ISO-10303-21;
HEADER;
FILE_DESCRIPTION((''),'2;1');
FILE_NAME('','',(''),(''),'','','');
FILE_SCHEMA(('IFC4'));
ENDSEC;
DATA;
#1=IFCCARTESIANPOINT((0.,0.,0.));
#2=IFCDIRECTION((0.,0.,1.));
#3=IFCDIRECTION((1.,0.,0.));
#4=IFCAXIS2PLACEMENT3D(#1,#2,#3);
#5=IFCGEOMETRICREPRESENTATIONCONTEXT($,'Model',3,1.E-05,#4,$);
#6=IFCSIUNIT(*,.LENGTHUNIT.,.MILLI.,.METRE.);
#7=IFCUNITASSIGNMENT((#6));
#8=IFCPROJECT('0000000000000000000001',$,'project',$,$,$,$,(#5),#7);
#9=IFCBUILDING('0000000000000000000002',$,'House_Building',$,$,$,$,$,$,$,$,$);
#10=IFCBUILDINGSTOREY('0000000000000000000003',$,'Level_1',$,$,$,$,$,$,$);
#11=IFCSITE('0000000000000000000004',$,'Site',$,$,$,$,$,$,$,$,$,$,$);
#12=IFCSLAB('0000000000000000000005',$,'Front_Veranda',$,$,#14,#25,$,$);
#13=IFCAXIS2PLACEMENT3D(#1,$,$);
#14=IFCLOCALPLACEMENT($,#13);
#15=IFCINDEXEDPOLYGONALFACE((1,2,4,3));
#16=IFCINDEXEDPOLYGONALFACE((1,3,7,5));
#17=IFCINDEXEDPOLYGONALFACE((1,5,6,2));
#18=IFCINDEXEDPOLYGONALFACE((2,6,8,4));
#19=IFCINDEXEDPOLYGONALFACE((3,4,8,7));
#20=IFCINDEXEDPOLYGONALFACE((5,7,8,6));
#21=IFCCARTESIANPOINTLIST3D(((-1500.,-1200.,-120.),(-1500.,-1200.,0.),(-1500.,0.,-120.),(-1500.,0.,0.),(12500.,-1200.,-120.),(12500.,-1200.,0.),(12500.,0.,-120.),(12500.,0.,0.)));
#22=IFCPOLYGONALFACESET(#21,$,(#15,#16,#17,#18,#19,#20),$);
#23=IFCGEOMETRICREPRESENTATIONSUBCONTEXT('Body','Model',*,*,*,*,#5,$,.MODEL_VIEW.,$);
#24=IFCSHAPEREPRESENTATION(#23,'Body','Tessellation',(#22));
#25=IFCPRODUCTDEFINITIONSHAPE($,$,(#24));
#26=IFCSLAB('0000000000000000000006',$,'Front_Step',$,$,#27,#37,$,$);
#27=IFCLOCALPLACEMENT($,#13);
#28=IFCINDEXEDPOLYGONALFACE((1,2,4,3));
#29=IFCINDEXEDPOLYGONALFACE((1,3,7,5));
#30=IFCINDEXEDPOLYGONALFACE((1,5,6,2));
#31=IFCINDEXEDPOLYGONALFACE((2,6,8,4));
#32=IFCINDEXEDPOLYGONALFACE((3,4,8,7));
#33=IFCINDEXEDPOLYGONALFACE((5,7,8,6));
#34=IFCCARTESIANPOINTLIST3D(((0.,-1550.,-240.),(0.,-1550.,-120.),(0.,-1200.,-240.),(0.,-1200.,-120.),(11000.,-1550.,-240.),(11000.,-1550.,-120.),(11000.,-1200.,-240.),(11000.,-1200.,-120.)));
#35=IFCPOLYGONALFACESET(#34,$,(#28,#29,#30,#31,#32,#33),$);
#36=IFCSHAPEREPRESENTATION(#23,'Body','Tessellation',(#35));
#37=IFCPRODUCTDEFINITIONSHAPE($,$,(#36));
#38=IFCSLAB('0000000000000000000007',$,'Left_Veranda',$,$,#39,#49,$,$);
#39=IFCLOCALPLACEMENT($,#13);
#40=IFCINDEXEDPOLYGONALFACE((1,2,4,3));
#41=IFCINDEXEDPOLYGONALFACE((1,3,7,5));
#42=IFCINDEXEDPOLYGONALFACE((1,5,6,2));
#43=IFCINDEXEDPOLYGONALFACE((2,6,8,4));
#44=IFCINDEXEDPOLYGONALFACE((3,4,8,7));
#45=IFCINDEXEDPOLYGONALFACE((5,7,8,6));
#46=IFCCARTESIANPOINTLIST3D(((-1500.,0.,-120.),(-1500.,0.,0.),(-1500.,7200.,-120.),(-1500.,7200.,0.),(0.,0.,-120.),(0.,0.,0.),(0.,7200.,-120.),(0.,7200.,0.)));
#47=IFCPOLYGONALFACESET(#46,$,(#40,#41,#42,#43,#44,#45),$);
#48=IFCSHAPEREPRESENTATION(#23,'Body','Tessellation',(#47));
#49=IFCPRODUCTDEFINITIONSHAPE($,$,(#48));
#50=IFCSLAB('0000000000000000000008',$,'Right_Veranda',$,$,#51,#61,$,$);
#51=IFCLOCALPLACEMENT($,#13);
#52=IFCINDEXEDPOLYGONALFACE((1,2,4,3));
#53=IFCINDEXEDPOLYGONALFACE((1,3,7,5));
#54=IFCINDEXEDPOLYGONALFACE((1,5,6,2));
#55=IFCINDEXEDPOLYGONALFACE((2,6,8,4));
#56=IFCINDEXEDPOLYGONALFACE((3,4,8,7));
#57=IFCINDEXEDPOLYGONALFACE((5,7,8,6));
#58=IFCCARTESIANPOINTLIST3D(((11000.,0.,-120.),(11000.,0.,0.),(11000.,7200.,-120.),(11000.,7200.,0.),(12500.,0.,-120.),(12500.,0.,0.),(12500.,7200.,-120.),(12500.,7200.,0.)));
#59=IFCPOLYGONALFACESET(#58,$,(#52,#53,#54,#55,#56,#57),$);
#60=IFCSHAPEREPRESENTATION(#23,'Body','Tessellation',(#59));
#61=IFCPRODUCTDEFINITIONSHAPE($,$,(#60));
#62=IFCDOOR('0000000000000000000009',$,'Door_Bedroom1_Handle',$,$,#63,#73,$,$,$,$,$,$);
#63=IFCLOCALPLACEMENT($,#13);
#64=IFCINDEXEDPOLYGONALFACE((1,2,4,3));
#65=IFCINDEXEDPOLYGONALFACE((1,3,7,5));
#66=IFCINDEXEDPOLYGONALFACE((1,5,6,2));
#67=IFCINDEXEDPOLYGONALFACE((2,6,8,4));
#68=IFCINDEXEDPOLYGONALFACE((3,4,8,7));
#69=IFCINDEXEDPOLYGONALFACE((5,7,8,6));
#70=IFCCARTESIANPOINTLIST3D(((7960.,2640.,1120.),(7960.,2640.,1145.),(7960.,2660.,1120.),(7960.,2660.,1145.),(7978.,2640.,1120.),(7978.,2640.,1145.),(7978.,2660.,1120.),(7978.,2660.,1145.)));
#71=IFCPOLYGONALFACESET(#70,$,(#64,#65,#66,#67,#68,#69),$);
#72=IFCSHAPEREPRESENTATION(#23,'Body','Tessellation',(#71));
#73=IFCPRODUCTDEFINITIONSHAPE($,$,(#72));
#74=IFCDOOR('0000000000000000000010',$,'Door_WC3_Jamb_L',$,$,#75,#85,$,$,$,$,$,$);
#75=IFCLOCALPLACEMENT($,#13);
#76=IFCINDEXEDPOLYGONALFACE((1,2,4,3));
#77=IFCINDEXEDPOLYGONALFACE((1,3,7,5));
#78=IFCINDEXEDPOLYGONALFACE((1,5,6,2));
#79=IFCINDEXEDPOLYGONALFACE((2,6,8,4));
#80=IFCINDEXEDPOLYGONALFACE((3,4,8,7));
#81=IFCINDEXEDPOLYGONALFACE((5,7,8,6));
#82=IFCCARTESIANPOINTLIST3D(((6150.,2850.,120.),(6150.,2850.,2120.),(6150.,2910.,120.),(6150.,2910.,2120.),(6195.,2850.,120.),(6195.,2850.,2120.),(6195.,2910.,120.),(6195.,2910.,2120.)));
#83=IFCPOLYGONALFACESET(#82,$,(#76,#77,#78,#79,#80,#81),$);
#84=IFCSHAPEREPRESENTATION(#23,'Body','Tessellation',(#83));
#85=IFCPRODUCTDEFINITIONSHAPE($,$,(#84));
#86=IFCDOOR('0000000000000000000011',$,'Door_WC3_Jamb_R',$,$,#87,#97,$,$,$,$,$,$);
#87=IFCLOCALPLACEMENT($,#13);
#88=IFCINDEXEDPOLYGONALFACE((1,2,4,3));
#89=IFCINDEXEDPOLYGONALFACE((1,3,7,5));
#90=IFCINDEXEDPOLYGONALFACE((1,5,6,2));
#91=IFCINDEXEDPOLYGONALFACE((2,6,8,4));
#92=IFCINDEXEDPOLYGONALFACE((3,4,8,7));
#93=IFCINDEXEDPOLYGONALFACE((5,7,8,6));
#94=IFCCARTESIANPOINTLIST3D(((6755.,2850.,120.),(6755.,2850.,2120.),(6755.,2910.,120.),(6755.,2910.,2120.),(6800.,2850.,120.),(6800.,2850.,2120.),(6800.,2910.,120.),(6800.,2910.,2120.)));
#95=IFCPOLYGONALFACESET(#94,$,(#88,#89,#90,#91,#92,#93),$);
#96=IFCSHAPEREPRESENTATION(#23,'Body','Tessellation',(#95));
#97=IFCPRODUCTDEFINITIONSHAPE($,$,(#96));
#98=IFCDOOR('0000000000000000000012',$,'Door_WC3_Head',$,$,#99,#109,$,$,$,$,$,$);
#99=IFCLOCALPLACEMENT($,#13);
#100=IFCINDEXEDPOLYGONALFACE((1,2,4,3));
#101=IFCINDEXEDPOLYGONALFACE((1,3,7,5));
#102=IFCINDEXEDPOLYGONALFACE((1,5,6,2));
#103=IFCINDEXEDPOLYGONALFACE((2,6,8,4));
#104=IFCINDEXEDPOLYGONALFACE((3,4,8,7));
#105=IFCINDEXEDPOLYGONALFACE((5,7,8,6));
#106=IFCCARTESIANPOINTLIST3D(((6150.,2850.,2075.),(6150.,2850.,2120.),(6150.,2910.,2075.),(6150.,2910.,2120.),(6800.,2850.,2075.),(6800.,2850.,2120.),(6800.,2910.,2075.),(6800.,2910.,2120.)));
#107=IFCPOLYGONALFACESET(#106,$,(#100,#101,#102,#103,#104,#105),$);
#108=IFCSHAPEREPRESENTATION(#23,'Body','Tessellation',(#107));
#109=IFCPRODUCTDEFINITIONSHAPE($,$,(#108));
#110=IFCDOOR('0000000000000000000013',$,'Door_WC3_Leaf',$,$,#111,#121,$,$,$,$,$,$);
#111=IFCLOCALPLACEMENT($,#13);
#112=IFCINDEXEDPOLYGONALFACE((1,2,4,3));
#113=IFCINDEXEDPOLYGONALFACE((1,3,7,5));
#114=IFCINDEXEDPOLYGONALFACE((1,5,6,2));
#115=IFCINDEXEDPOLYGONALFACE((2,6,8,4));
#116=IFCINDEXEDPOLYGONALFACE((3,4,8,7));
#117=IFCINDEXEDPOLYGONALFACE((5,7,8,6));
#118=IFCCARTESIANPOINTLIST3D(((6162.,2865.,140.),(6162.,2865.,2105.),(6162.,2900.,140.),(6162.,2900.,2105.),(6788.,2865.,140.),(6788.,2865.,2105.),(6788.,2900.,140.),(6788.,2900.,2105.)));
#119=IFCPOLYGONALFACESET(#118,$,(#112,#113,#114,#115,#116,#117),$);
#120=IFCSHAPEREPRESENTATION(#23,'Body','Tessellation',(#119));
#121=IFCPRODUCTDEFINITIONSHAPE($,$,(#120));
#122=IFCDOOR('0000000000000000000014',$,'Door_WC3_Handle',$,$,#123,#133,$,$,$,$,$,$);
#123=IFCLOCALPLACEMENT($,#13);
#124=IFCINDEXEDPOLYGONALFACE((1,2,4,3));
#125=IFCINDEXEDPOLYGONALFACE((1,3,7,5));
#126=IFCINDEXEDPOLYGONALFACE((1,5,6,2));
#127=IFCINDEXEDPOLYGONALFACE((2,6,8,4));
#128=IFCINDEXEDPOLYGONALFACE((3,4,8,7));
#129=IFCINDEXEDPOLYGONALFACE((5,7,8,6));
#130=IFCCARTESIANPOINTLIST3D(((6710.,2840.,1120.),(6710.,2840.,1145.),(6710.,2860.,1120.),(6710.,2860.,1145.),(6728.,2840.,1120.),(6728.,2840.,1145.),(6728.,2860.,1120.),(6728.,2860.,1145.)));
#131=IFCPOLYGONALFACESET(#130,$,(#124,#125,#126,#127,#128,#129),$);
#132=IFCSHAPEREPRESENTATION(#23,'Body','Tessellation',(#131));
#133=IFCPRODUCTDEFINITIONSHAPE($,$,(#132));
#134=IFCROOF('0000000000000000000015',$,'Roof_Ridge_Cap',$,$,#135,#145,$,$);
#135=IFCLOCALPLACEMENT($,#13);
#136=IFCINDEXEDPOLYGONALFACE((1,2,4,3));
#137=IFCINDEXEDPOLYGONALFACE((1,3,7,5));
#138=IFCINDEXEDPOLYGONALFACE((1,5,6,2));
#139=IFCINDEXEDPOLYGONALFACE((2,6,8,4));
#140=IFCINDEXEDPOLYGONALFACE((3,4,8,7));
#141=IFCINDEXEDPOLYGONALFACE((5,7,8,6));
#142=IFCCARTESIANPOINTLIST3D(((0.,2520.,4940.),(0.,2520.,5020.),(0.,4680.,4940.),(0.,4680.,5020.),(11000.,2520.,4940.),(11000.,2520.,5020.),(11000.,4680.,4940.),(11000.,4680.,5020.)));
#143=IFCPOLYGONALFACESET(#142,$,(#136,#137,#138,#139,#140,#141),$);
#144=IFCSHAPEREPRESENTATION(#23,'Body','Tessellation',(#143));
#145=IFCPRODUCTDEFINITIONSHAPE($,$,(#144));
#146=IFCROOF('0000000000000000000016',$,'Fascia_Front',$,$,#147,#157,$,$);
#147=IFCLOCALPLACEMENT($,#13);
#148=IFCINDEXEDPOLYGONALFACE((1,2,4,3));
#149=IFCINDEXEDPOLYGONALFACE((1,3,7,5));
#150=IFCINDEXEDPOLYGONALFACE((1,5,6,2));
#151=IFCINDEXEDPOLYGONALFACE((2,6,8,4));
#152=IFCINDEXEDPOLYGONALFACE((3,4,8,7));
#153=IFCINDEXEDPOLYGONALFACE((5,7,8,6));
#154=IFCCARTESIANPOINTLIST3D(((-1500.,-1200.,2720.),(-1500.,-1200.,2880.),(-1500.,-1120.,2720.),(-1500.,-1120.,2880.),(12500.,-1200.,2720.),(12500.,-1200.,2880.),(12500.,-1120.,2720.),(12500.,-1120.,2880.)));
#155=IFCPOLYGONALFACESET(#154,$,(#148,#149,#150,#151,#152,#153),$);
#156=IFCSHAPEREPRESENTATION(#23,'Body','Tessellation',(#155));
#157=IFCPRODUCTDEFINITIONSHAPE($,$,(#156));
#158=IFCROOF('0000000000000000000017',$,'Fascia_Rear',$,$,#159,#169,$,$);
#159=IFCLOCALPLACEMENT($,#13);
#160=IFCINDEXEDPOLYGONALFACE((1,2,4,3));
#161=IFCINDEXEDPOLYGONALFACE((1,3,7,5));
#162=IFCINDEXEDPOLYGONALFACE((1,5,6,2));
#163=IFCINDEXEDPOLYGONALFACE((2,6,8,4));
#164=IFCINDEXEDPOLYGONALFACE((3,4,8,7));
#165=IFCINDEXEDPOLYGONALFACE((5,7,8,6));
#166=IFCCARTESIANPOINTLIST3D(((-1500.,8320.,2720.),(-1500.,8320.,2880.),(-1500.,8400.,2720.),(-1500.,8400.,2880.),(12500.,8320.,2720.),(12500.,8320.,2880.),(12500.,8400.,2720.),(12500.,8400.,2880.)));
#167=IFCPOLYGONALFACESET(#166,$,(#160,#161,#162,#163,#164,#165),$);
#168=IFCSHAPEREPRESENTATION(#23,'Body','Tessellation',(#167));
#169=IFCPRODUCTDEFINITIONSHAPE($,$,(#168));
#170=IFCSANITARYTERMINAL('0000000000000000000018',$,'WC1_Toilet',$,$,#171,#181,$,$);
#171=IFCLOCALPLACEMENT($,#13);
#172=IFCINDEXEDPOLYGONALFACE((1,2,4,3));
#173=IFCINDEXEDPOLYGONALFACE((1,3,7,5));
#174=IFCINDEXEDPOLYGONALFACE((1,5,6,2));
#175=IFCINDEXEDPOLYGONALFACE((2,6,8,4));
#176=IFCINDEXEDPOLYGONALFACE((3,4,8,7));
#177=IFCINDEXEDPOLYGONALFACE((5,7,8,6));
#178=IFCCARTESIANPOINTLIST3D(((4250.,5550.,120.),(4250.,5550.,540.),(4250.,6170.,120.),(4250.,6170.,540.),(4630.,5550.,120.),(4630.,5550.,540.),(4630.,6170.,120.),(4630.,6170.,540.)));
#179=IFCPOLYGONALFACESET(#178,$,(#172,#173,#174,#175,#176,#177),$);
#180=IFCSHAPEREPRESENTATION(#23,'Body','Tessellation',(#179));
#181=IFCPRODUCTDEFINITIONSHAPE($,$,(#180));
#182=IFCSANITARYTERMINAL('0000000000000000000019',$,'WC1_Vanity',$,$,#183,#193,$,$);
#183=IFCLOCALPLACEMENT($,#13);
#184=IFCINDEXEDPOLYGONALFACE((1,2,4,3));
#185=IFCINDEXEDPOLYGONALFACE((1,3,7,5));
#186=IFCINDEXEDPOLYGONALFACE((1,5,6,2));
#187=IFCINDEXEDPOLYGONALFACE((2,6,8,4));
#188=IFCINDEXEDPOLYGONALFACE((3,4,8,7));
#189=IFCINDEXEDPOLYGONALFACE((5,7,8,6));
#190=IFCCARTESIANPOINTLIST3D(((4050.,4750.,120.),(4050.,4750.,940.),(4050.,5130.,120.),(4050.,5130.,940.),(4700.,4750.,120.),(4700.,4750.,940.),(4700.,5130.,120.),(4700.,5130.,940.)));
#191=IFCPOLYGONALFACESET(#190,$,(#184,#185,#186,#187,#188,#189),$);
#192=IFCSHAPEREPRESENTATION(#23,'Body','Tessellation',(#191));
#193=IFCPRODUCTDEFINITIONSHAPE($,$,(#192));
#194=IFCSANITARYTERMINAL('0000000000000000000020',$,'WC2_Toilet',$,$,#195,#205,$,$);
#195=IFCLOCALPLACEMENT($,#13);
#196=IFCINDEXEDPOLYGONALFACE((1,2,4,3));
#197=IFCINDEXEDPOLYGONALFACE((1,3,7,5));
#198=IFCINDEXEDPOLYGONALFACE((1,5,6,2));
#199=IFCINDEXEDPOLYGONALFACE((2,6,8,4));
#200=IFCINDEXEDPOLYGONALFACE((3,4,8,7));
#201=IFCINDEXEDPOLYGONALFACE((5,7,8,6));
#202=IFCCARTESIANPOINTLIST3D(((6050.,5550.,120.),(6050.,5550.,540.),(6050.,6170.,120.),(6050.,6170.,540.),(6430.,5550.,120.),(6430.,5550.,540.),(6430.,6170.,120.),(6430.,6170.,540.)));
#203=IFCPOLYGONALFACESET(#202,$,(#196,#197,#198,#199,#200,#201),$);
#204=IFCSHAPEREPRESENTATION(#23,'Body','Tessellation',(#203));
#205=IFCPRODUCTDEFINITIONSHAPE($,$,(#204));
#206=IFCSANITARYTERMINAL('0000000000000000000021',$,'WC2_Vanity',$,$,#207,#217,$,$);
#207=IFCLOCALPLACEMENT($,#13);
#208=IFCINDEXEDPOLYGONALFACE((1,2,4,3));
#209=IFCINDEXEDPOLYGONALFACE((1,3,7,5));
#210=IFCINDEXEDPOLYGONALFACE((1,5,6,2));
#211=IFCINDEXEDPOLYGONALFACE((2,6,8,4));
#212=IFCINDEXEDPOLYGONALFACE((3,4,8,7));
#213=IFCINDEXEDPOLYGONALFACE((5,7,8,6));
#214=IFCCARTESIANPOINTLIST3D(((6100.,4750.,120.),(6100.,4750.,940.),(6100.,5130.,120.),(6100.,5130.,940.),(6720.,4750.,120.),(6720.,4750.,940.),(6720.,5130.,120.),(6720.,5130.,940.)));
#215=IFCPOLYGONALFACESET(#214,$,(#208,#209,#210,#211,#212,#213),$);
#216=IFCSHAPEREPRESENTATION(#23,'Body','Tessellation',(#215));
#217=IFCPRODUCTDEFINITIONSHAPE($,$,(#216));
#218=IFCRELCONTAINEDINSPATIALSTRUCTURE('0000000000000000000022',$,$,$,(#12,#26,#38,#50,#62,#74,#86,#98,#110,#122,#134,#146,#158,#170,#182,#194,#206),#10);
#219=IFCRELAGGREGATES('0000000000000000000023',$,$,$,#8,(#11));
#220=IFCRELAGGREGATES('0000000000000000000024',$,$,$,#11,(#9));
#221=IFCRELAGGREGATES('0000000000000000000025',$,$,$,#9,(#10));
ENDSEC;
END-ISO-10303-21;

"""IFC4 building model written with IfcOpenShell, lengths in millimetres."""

from ifc_helpers import new_model, si_unit, frame, origin_with_axes, context, subcontext, project, spatial, polyline, outline, extrude, element, save


model = new_model("IFC4")

# Units and contexts
model_context = context("Model", 3, precision=1e-05, world=origin_with_axes())
body_context = subcontext(model_context, "Body", "Model", "MODEL_VIEW")
ifc_project = project(units=[si_unit("LENGTHUNIT", "METRE", prefix="MILLI")], contexts=[model_context])

# Site, building, storey
site = spatial("IfcSite", under=ifc_project, Name="Site")
building = spatial("IfcBuilding", under=site, Name="House_Building")
storey = spatial("IfcBuildingStorey", under=building, Name="Level_1")

# Slabs
element("IfcSlab", 1, inside=storey, Name="Front_Veranda", context=body_context, shape_type="SweptSolid", body=[
    extrude(outline(polyline([(-1500.0, -1200.0), (12500.0, -1200.0), (12500.0, 0.0), (-1500.0, 0.0), (-1500.0, -1200.0)])), frame((0.0, 0.0, -120.0), z_axis=(0.0, 0.0, 1.0), x_axis=(1.0, 0.0, 0.0)), (0.0, 0.0, 1.0), 120.0),
])
element("IfcSlab", 2, inside=storey, Name="Front_Step", context=body_context, shape_type="SweptSolid", body=[
    extrude(outline(polyline([(0.0, -1550.0), (11000.0, -1550.0), (11000.0, -1200.0), (0.0, -1200.0), (0.0, -1550.0)])), frame((0.0, 0.0, -240.0), z_axis=(0.0, 0.0, 1.0), x_axis=(1.0, 0.0, 0.0)), (0.0, 0.0, 1.0), 120.0),
])
element("IfcSlab", 3, inside=storey, Name="Left_Veranda", context=body_context, shape_type="SweptSolid", body=[
    extrude(outline(polyline([(-1500.0, 0.0), (0.0, 0.0), (0.0, 7200.0), (-1500.0, 7200.0), (-1500.0, 0.0)])), frame((0.0, 0.0, -120.0), z_axis=(0.0, 0.0, 1.0), x_axis=(1.0, 0.0, 0.0)), (0.0, 0.0, 1.0), 120.0),
])
element("IfcSlab", 4, inside=storey, Name="Right_Veranda", context=body_context, shape_type="SweptSolid", body=[
    extrude(outline(polyline([(11000.0, 0.0), (12500.0, 0.0), (12500.0, 7200.0), (11000.0, 7200.0), (11000.0, 0.0)])), frame((0.0, 0.0, -120.0), z_axis=(0.0, 0.0, 1.0), x_axis=(1.0, 0.0, 0.0)), (0.0, 0.0, 1.0), 120.0),
])

# Doors
element("IfcDoor", 5, inside=storey, Name="Door_Bedroom1_Handle", context=body_context, shape_type="SweptSolid", body=[
    extrude(outline(polyline([(7960.0, 2640.0), (7978.0, 2640.0), (7978.0, 2660.0), (7960.0, 2660.0), (7960.0, 2640.0)])), frame((0.0, 0.0, 1120.0), z_axis=(0.0, 0.0, 1.0), x_axis=(1.0, 0.0, 0.0)), (0.0, 0.0, 1.0), 25.0),
])
element("IfcDoor", 6, inside=storey, Name="Door_WC3_Jamb_L", context=body_context, shape_type="SweptSolid", body=[
    extrude(outline(polyline([(6150.0, 2850.0), (6195.0, 2850.0), (6195.0, 2910.0), (6150.0, 2910.0), (6150.0, 2850.0)])), frame((0.0, 0.0, 120.0), z_axis=(0.0, 0.0, 1.0), x_axis=(1.0, 0.0, 0.0)), (0.0, 0.0, 1.0), 2000.0),
])
element("IfcDoor", 7, inside=storey, Name="Door_WC3_Jamb_R", context=body_context, shape_type="SweptSolid", body=[
    extrude(outline(polyline([(6755.0, 2850.0), (6800.0, 2850.0), (6800.0, 2910.0), (6755.0, 2910.0), (6755.0, 2850.0)])), frame((0.0, 0.0, 120.0), z_axis=(0.0, 0.0, 1.0), x_axis=(1.0, 0.0, 0.0)), (0.0, 0.0, 1.0), 2000.0),
])
element("IfcDoor", 8, inside=storey, Name="Door_WC3_Head", context=body_context, shape_type="SweptSolid", body=[
    extrude(outline(polyline([(6150.0, 2850.0), (6800.0, 2850.0), (6800.0, 2910.0), (6150.0, 2910.0), (6150.0, 2850.0)])), frame((0.0, 0.0, 2075.0), z_axis=(0.0, 0.0, 1.0), x_axis=(1.0, 0.0, 0.0)), (0.0, 0.0, 1.0), 45.0),
])
element("IfcDoor", 9, inside=storey, Name="Door_WC3_Leaf", context=body_context, shape_type="SweptSolid", body=[
    extrude(outline(polyline([(6162.0, 2865.0), (6788.0, 2865.0), (6788.0, 2900.0), (6162.0, 2900.0), (6162.0, 2865.0)])), frame((0.0, 0.0, 140.0), z_axis=(0.0, 0.0, 1.0), x_axis=(1.0, 0.0, 0.0)), (0.0, 0.0, 1.0), 1965.0),
])
element("IfcDoor", 10, inside=storey, Name="Door_WC3_Handle", context=body_context, shape_type="SweptSolid", body=[
    extrude(outline(polyline([(6710.0, 2840.0), (6728.0, 2840.0), (6728.0, 2860.0), (6710.0, 2860.0), (6710.0, 2840.0)])), frame((0.0, 0.0, 1120.0), z_axis=(0.0, 0.0, 1.0), x_axis=(1.0, 0.0, 0.0)), (0.0, 0.0, 1.0), 25.0),
])

# Roofs
element("IfcRoof", 11, inside=storey, Name="Roof_Ridge_Cap", context=body_context, shape_type="SweptSolid", body=[
    extrude(outline(polyline([(0.0, 2520.0), (11000.0, 2520.0), (11000.0, 4680.0), (0.0, 4680.0), (0.0, 2520.0)])), frame((0.0, 0.0, 4940.0), z_axis=(0.0, 0.0, 1.0), x_axis=(1.0, 0.0, 0.0)), (0.0, 0.0, 1.0), 80.0),
])
element("IfcRoof", 12, inside=storey, Name="Fascia_Front", context=body_context, shape_type="SweptSolid", body=[
    extrude(outline(polyline([(-1500.0, -1200.0), (12500.0, -1200.0), (12500.0, -1120.0), (-1500.0, -1120.0), (-1500.0, -1200.0)])), frame((0.0, 0.0, 2720.0), z_axis=(0.0, 0.0, 1.0), x_axis=(1.0, 0.0, 0.0)), (0.0, 0.0, 1.0), 160.0),
])
element("IfcRoof", 13, inside=storey, Name="Fascia_Rear", context=body_context, shape_type="SweptSolid", body=[
    extrude(outline(polyline([(-1500.0, 8320.0), (12500.0, 8320.0), (12500.0, 8400.0), (-1500.0, 8400.0), (-1500.0, 8320.0)])), frame((0.0, 0.0, 2720.0), z_axis=(0.0, 0.0, 1.0), x_axis=(1.0, 0.0, 0.0)), (0.0, 0.0, 1.0), 160.0),
])

# Sanitary terminals
element("IfcSanitaryTerminal", 14, inside=storey, Name="WC1_Toilet", context=body_context, shape_type="SweptSolid", body=[
    extrude(outline(polyline([(4250.0, 5550.0), (4630.0, 5550.0), (4630.0, 6170.0), (4250.0, 6170.0), (4250.0, 5550.0)])), frame((0.0, 0.0, 120.0), z_axis=(0.0, 0.0, 1.0), x_axis=(1.0, 0.0, 0.0)), (0.0, 0.0, 1.0), 420.0),
])
element("IfcSanitaryTerminal", 15, inside=storey, Name="WC1_Vanity", context=body_context, shape_type="SweptSolid", body=[
    extrude(outline(polyline([(4050.0, 4750.0), (4700.0, 4750.0), (4700.0, 5130.0), (4050.0, 5130.0), (4050.0, 4750.0)])), frame((0.0, 0.0, 120.0), z_axis=(0.0, 0.0, 1.0), x_axis=(1.0, 0.0, 0.0)), (0.0, 0.0, 1.0), 820.0),
])
element("IfcSanitaryTerminal", 16, inside=storey, Name="WC2_Toilet", context=body_context, shape_type="SweptSolid", body=[
    extrude(outline(polyline([(6050.0, 5550.0), (6430.0, 5550.0), (6430.0, 6170.0), (6050.0, 6170.0), (6050.0, 5550.0)])), frame((0.0, 0.0, 120.0), z_axis=(0.0, 0.0, 1.0), x_axis=(1.0, 0.0, 0.0)), (0.0, 0.0, 1.0), 420.0),
])
element("IfcSanitaryTerminal", 17, inside=storey, Name="WC2_Vanity", context=body_context, shape_type="SweptSolid", body=[
    extrude(outline(polyline([(6100.0, 4750.0), (6720.0, 4750.0), (6720.0, 5130.0), (6100.0, 5130.0), (6100.0, 4750.0)])), frame((0.0, 0.0, 120.0), z_axis=(0.0, 0.0, 1.0), x_axis=(1.0, 0.0, 0.0)), (0.0, 0.0, 1.0), 820.0),
])

save(model, "model.ifc")
